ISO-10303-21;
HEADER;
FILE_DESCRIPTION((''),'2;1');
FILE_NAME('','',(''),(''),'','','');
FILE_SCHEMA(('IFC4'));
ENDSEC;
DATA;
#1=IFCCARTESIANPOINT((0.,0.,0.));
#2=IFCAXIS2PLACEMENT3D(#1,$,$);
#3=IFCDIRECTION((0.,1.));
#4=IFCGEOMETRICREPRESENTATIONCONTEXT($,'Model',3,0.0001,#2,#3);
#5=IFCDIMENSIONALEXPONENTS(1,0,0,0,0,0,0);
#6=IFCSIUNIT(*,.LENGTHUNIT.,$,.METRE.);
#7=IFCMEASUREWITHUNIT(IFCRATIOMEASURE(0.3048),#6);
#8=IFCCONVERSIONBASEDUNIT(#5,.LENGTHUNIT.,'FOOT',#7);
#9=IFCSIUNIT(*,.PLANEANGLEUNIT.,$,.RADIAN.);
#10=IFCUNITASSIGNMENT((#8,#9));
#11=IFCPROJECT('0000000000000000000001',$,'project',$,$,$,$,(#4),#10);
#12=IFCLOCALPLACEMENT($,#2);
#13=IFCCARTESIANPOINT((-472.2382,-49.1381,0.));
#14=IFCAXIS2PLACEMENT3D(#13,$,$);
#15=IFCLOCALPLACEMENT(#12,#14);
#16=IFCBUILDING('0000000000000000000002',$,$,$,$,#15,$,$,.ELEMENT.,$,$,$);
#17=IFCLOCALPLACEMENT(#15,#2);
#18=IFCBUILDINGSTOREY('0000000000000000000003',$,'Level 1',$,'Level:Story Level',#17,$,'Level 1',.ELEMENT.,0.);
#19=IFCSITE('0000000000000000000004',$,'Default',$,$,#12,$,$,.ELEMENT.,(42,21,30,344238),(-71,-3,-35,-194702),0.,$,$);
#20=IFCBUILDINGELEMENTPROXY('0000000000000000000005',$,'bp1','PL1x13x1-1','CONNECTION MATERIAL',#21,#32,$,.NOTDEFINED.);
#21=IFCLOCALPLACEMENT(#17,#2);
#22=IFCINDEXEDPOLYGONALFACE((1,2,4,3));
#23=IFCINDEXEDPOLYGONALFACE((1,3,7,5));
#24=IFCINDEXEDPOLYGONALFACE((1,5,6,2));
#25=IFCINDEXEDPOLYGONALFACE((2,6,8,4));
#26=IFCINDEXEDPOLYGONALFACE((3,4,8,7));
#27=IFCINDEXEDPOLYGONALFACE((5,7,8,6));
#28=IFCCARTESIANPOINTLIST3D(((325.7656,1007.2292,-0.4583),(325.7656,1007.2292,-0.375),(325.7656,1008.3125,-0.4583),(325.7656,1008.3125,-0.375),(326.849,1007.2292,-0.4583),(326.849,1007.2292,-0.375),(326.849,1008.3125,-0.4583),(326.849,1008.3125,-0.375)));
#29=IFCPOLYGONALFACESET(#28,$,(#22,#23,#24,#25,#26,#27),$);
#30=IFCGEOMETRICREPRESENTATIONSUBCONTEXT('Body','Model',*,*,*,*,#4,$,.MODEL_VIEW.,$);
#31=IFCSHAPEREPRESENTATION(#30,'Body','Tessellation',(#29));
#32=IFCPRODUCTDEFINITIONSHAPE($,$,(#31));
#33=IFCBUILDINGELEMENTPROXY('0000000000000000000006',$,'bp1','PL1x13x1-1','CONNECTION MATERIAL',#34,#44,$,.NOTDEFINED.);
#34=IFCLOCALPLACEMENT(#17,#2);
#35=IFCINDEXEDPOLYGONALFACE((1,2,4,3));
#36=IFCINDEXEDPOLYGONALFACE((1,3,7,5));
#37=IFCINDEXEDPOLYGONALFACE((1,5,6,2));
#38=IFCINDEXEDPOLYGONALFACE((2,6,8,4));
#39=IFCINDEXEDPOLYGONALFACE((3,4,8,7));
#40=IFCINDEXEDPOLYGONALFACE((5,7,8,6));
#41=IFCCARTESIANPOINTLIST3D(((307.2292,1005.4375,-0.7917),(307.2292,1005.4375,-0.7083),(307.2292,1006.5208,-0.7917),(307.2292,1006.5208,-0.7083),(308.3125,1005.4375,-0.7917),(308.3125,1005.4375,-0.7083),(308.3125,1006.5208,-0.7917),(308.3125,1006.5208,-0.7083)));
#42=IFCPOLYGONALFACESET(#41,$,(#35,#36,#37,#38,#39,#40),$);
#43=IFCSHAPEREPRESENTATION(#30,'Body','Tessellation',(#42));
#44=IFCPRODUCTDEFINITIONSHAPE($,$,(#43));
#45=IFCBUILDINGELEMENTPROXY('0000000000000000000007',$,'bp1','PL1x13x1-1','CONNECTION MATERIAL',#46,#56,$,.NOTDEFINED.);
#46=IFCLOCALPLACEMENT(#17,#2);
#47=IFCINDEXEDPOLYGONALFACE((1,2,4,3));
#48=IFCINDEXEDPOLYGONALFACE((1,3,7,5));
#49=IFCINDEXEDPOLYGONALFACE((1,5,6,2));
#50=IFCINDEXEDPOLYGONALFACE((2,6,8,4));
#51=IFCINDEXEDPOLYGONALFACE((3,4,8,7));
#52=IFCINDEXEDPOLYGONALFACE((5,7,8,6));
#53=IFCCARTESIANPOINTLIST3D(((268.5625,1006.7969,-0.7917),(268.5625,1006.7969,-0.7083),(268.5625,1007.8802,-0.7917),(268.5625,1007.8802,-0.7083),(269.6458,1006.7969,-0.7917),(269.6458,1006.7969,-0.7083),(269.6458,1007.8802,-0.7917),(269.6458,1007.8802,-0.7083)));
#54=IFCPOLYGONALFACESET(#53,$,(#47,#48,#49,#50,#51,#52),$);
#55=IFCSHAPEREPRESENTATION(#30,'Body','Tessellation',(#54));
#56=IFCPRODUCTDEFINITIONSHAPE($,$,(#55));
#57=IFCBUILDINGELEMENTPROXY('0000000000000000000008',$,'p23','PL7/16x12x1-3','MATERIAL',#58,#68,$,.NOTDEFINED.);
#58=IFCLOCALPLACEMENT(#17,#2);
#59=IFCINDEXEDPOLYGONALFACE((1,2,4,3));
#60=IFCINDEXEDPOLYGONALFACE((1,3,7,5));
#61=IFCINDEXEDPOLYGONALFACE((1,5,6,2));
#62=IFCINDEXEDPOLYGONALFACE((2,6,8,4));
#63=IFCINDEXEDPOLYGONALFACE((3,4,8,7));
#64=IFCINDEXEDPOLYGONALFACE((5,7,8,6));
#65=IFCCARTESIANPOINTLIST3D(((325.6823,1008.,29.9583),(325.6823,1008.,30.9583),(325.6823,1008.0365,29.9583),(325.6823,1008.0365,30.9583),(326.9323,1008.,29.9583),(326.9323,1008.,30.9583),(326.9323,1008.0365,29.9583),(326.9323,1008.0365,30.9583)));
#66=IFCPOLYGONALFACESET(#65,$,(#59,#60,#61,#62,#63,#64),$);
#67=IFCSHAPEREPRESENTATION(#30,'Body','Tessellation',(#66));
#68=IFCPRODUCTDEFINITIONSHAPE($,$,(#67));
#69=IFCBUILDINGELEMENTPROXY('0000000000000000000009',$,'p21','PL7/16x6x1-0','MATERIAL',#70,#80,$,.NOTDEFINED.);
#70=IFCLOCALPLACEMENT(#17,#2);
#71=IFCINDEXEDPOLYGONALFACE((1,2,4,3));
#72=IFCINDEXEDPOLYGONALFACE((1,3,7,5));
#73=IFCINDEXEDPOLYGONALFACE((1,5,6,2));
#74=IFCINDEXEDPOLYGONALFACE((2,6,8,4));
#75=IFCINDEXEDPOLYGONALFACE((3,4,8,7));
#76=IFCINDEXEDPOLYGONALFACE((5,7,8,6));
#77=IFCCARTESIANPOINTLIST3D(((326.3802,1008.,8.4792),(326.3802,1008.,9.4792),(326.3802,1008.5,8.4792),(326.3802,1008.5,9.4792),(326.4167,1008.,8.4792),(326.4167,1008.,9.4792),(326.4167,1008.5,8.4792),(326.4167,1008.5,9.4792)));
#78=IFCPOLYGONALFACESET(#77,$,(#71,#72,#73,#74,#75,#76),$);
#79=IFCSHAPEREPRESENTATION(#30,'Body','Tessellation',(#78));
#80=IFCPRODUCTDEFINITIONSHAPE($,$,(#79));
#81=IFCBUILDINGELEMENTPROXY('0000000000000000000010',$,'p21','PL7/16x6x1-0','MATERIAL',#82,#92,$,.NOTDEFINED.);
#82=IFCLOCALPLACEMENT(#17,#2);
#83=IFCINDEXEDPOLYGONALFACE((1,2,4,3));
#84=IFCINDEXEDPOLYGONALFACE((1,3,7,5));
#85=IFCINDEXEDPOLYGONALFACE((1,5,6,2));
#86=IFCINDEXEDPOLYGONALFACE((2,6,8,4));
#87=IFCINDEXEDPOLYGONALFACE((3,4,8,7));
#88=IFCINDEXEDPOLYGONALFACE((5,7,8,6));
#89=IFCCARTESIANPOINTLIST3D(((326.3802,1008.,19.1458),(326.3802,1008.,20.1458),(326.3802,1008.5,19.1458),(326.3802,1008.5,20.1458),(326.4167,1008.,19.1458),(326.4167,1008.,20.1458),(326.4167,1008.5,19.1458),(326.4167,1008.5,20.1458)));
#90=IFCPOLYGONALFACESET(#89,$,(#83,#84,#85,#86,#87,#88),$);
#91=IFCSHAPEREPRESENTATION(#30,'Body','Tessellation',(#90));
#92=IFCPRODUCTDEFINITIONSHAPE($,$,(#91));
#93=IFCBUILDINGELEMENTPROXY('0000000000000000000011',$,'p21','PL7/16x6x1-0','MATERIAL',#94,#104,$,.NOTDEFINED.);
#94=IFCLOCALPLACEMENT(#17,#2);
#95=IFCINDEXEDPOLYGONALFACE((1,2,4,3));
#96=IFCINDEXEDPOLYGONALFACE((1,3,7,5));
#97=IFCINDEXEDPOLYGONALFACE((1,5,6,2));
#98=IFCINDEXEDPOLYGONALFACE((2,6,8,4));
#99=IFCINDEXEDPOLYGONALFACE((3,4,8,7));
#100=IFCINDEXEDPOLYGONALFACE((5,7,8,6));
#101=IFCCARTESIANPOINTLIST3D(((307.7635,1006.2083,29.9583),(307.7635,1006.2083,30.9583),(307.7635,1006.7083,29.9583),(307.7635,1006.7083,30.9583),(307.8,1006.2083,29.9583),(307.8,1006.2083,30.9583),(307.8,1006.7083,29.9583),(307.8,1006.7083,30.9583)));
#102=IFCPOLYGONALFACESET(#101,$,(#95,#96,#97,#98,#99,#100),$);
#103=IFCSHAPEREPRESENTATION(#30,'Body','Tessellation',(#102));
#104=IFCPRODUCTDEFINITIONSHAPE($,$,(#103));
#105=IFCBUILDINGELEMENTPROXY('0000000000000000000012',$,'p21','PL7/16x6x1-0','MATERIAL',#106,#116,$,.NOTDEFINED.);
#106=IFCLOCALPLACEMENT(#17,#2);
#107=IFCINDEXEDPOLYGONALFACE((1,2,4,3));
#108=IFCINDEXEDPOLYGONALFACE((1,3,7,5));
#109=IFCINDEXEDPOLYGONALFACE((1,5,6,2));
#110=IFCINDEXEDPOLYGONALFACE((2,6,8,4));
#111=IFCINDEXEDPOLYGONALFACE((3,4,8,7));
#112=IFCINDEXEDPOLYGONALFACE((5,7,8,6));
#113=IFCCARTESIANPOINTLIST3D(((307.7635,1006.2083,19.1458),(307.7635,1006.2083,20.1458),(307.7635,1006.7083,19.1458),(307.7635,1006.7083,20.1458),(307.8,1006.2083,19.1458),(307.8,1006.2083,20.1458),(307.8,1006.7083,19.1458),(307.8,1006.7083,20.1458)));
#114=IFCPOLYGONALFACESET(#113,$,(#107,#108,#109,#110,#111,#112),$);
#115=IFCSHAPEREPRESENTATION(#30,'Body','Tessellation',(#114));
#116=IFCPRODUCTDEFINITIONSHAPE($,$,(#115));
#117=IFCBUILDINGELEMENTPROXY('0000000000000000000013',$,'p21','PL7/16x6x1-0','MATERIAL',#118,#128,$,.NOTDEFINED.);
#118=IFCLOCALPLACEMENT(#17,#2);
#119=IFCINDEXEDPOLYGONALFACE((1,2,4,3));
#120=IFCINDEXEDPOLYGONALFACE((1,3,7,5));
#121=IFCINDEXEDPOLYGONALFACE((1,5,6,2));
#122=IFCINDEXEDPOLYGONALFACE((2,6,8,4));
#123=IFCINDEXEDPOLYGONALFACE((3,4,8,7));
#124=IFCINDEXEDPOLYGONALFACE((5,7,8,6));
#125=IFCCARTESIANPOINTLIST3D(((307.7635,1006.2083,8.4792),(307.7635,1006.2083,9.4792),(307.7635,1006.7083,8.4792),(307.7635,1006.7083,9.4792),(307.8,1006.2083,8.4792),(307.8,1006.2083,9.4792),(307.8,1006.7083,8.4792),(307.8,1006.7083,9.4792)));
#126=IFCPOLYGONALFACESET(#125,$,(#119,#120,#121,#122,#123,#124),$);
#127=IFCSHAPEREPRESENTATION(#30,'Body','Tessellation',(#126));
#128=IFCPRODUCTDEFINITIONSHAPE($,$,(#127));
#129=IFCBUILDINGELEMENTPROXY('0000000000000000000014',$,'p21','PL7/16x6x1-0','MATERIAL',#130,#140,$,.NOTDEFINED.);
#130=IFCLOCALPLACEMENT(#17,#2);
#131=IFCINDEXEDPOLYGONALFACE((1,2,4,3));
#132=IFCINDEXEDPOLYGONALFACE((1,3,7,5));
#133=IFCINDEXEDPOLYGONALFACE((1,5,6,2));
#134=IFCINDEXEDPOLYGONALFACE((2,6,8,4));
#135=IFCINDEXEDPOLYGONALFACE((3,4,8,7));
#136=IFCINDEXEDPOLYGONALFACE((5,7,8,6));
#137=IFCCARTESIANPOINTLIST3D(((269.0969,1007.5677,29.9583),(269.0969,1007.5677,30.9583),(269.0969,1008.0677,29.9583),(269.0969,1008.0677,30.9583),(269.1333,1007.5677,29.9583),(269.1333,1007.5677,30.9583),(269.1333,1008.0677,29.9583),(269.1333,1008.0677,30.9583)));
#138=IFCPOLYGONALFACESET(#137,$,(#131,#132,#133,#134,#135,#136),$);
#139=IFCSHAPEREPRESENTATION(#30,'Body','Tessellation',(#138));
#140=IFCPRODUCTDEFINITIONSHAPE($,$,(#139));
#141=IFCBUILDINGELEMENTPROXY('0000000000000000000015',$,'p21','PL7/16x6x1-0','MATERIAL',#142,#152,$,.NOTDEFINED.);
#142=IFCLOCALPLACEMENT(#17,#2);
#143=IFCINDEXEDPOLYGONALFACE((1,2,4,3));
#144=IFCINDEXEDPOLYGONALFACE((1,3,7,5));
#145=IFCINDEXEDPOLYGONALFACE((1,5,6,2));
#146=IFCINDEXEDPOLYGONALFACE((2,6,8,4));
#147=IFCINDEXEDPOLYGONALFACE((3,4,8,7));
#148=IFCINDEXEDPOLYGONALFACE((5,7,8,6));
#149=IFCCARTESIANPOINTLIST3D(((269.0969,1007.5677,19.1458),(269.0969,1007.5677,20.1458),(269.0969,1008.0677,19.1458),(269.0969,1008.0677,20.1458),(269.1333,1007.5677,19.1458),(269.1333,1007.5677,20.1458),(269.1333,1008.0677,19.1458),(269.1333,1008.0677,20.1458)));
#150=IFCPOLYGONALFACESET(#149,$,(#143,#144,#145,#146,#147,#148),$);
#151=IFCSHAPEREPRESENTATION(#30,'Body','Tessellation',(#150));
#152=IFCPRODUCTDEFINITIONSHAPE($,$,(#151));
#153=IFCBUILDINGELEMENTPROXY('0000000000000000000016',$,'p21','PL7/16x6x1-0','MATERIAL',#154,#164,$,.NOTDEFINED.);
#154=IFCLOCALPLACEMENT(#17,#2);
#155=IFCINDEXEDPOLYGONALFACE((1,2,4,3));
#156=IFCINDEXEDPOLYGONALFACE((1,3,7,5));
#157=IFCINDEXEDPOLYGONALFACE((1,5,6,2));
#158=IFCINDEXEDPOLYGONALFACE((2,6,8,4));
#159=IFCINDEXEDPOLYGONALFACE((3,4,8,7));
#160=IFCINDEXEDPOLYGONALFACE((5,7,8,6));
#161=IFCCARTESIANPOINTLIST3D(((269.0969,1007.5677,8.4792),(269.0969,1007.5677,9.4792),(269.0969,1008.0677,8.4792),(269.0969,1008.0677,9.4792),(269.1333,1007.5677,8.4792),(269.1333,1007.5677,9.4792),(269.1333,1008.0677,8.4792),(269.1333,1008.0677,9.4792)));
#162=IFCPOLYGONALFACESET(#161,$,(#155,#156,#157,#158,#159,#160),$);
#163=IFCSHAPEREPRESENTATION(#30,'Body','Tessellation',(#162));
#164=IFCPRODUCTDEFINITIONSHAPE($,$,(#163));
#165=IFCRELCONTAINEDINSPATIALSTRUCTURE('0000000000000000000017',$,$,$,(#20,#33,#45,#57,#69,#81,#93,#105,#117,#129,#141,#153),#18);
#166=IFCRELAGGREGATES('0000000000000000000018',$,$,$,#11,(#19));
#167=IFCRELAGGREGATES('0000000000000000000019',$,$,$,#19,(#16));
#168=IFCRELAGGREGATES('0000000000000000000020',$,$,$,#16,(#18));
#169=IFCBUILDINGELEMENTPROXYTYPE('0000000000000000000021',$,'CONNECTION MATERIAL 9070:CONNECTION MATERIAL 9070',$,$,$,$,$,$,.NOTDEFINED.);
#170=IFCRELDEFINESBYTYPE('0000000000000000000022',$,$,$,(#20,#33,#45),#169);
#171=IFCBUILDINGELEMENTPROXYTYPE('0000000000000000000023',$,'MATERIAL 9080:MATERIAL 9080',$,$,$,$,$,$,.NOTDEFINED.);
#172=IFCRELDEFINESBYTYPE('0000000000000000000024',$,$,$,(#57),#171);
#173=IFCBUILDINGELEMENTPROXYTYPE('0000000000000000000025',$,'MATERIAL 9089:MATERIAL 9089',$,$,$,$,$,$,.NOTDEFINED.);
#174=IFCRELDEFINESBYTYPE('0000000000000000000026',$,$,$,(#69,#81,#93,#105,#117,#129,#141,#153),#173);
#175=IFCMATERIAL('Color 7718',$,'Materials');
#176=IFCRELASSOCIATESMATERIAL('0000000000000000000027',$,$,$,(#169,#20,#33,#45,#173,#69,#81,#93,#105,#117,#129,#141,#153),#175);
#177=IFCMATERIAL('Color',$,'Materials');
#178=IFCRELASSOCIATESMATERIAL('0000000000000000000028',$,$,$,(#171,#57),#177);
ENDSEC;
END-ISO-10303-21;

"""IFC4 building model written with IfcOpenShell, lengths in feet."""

from ifc_helpers import new_model, entity, si_unit, converted_unit, direction, frame, origin, origin_2d_with_axis, place, context, subcontext, project, spatial, rectangle, extrude, source, transform, mapped, material, type_object, type_shapes, element, save


model = new_model("IFC4")

# Units and contexts
model_context = context("Model", 3, precision=0.0001, world=origin(), true_north=direction((0.0, 1.0)))
body_context = subcontext(model_context, "Body", "Model", "MODEL_VIEW")
ifc_project = project(units=[converted_unit("LENGTHUNIT", "FOOT", entity("IfcRatioMeasure", 0.3048), si_unit("LENGTHUNIT", "METRE"), dimensions=[1, 0, 0, 0, 0, 0, 0]), si_unit("PLANEANGLEUNIT", "RADIAN")], contexts=[model_context])

# Site, building, storey
site_placement = place(None, origin())
site = spatial("IfcSite", under=ifc_project, at=site_placement, Name="Default", CompositionType="ELEMENT", RefLatitude=(42, 21, 30, 344238), RefLongitude=(-71, -3, -35, -194702), RefElevation=0.0)
building_placement = place(site_placement, frame((-472.2382, -49.1381, 0.0)))
building = spatial("IfcBuilding", under=site, at=building_placement, CompositionType="ELEMENT")
storey_placement = place(building_placement, origin())
storey = spatial("IfcBuildingStorey", under=building, at=storey_placement, Name="Level 1", ObjectType="Level:Story Level", LongName="Level 1", CompositionType="ELEMENT", Elevation=0.0)

# Building element proxies
ifc_material_1 = material(Name="Color 7718", Category="Materials")
building_element_proxy_type_1 = type_object("IfcBuildingElementProxyType", Name="CONNECTION MATERIAL 9070:CONNECTION MATERIAL 9070", PredefinedType="NOTDEFINED", material=ifc_material_1)
shared_shape_1 = source(origin(), body_context, "Body", "SweptSolid", [
    extrude(rectangle(XDim=1.0833, YDim=1.0833, at=origin_2d_with_axis()), frame((0.0, 0.0, -0.0833)), (0.0, 0.0, 1.0), 0.0833),
])
type_shapes(building_element_proxy_type_1, [shared_shape_1])
for number, where, name in (
    (1, (326.3073, 1007.7708, -0.375), "bp1"),
    (2, (307.7708, 1005.9792, -0.7083), "bp1"),
    (3, (269.1042, 1007.3385, -0.7083), "bp1"),
):
    element("IfcBuildingElementProxy", number, at=place(building_placement, frame(where)), inside=storey, type_object=building_element_proxy_type_1, material=ifc_material_1, Name=name, Description="PL1x13x1-1", ObjectType="CONNECTION MATERIAL", PredefinedType="NOTDEFINED", context=body_context, shape_type="MappedRepresentation", body=[
        mapped(shared_shape_1, transform((0.0, 0.0, 0.0), scale=1.0)),
    ])
ifc_material_2 = material(Name="Color", Category="Materials")
building_element_proxy_type_2 = type_object("IfcBuildingElementProxyType", Name="MATERIAL 9080:MATERIAL 9080", PredefinedType="NOTDEFINED", material=ifc_material_2)
shared_shape_2 = source(origin(), body_context, "Body", "SweptSolid", [
    extrude(rectangle(XDim=1.25, YDim=1.0, at=origin_2d_with_axis()), frame((0.625, -0.5, 0.0)), (0.0, 0.0, 1.0), 0.0365),
])
type_shapes(building_element_proxy_type_2, [shared_shape_2])
proxy_1_placement = place(building_placement, frame((325.6823, 1008.0365, 30.9583), z_axis=(0.0, -1.0, 0.0), x_axis=(1.0, 0.0, 0.0)))
element("IfcBuildingElementProxy", 4, at=proxy_1_placement, inside=storey, type_object=building_element_proxy_type_2, material=ifc_material_2, Name="p23", Description="PL7/16x12x1-3", ObjectType="MATERIAL", PredefinedType="NOTDEFINED", context=body_context, shape_type="MappedRepresentation", body=[
    mapped(shared_shape_2, transform((0.0, 0.0, 0.0), scale=1.0)),
])
building_element_proxy_type_3 = type_object("IfcBuildingElementProxyType", Name="MATERIAL 9089:MATERIAL 9089", PredefinedType="NOTDEFINED", material=ifc_material_1)
shared_shape_3 = source(origin(), body_context, "Body", "SweptSolid", [
    extrude(rectangle(XDim=1.0, YDim=0.5, at=origin_2d_with_axis()), frame((0.5, -0.25, 0.0)), (0.0, 0.0, 1.0), 0.0365),
])
type_shapes(building_element_proxy_type_3, [shared_shape_3])
for number, where, z_axis, x_axis, name in (
    (5, (326.4167, 1008.0, 9.4792), (-1.0, 0.0, 0.0), (0.0, 0.0, -1.0), "p21"),
    (6, (326.4167, 1008.0, 20.1458), (-1.0, 0.0, 0.0), (0.0, 0.0, -1.0), "p21"),
    (7, (307.8, 1006.2083, 30.9583), (-1.0, 0.0, 0.0), (0.0, 0.0, -1.0), "p21"),
    (8, (307.8, 1006.2083, 20.1458), (-1.0, 0.0, 0.0), (0.0, 0.0, -1.0), "p21"),
    (9, (307.8, 1006.2083, 9.4792), (-1.0, 0.0, 0.0), (0.0, 0.0, -1.0), "p21"),
    (10, (269.1333, 1007.5677, 30.9583), (-1.0, 0.0, 0.0), (0.0, 0.0, -1.0), "p21"),
    (11, (269.1333, 1007.5677, 20.1458), (-1.0, 0.0, 0.0), (0.0, 0.0, -1.0), "p21"),
    (12, (269.1333, 1007.5677, 9.4792), (-1.0, 0.0, 0.0), (0.0, 0.0, -1.0), "p21"),
):
    element("IfcBuildingElementProxy", number, at=place(building_placement, frame(where, z_axis=z_axis, x_axis=x_axis)), inside=storey, type_object=building_element_proxy_type_3, material=ifc_material_1, Name=name, Description="PL7/16x6x1-0", ObjectType="MATERIAL", PredefinedType="NOTDEFINED", context=body_context, shape_type="MappedRepresentation", body=[
        mapped(shared_shape_3, transform((0.0, 0.0, 0.0), scale=1.0)),
    ])

save(model, "model.ifc")
